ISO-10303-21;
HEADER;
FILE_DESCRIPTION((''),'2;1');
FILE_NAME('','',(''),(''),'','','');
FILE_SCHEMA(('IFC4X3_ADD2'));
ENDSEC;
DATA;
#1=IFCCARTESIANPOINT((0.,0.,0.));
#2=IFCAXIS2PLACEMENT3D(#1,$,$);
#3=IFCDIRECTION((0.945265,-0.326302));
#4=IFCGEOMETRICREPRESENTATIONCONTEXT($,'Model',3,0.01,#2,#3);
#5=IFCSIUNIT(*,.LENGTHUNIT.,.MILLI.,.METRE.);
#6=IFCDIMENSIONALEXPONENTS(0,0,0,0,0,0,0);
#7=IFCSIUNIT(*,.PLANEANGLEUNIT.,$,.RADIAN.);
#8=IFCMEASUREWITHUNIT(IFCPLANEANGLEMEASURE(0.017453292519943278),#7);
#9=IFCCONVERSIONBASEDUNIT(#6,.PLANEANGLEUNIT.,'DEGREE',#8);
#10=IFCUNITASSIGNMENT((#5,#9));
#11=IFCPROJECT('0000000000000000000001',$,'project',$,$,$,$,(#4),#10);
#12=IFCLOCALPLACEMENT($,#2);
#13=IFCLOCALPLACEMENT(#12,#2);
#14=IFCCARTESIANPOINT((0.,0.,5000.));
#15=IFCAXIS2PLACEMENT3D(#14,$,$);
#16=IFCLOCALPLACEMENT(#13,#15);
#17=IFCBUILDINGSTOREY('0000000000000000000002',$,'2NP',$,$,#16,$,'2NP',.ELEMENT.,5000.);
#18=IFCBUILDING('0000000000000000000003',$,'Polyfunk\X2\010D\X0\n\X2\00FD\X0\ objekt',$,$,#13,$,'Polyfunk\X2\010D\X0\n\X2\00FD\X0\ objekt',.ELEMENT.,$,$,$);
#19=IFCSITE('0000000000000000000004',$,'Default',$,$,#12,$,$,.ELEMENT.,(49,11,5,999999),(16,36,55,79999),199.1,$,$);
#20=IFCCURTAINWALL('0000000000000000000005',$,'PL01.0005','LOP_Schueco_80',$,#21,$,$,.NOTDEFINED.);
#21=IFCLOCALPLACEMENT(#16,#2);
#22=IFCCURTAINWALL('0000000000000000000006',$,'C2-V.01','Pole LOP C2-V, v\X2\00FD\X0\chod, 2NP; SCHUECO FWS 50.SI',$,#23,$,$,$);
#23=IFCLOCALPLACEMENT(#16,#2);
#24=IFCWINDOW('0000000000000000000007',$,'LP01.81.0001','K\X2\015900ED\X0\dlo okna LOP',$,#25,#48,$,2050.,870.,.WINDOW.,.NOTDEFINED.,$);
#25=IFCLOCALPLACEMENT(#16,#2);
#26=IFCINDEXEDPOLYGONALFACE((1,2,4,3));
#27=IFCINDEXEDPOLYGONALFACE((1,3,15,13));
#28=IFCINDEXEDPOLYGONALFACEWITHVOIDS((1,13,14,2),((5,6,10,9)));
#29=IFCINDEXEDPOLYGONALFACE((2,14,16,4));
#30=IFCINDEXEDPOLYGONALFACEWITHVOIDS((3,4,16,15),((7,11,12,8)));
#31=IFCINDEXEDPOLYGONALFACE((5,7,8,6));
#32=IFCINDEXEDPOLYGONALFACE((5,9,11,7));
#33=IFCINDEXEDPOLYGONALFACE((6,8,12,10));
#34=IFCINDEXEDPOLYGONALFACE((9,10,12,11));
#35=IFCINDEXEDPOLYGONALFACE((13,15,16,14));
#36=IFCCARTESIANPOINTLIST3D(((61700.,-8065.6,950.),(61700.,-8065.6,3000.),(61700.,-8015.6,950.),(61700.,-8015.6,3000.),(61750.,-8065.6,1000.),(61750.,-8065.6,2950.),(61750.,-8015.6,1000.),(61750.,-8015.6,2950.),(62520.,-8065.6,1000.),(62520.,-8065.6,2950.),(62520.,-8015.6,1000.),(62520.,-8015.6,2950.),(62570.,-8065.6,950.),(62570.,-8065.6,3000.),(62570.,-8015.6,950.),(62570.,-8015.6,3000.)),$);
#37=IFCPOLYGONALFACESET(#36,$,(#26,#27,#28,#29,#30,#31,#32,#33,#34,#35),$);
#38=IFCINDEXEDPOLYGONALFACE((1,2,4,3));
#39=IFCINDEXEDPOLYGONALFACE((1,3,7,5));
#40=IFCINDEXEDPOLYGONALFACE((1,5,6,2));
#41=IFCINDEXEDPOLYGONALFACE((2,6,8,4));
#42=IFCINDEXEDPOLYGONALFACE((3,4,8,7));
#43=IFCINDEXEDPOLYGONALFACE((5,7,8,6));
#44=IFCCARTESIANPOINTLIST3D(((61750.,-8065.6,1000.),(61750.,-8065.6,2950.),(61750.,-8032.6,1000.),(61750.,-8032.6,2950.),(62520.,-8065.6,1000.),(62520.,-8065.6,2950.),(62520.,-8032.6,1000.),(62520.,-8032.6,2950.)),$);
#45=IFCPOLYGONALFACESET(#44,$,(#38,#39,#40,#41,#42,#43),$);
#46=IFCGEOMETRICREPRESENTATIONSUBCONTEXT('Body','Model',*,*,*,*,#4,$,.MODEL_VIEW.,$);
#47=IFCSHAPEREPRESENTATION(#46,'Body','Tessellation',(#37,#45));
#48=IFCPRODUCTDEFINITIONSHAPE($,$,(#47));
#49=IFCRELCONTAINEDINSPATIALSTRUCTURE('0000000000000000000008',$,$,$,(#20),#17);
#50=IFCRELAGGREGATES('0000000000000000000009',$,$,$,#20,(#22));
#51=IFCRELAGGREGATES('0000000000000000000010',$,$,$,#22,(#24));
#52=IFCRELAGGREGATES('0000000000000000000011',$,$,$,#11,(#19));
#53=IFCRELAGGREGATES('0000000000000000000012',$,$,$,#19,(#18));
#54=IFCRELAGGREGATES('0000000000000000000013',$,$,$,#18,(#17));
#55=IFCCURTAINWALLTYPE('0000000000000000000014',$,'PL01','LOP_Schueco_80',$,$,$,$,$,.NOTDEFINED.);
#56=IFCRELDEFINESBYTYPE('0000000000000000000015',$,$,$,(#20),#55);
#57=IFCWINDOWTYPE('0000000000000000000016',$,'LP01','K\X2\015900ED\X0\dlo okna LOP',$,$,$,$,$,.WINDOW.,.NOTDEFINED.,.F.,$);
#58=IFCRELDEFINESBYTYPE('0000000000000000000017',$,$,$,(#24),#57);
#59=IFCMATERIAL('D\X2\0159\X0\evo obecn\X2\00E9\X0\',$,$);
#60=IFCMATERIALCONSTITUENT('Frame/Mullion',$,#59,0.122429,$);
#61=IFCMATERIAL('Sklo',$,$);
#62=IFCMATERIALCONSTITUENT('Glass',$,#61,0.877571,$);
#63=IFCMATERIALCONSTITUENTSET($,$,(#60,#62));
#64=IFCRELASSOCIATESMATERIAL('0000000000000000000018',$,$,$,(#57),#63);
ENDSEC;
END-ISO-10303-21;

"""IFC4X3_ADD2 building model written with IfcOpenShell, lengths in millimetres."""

from ifc_helpers import new_model, entity, si_unit, converted_unit, direction, frame, frame_2d, origin, place, context, subcontext, project, spatial, polyline, rectangle, outline, extrude, source, transform, mapped, material, constituent, constituent_set, type_object, element, aggregate, save


model = new_model("IFC4X3_ADD2")

# Units and contexts
model_context = context("Model", 3, precision=0.01, world=origin(), true_north=direction((0.945265, -0.326302)))
body_context = subcontext(model_context, "Body", "Model", "MODEL_VIEW")
ifc_project = project(units=[si_unit("LENGTHUNIT", "METRE", prefix="MILLI"), converted_unit("PLANEANGLEUNIT", "DEGREE", entity("IfcPlaneAngleMeasure", 0.017453292519943278), si_unit("PLANEANGLEUNIT", "RADIAN"), dimensions=[0, 0, 0, 0, 0, 0, 0])], contexts=[model_context])

# Site, building, storey
site_placement = place(None, origin())
site = spatial("IfcSite", under=ifc_project, at=site_placement, Name="Default", CompositionType="ELEMENT", RefLatitude=(49, 11, 5, 999999), RefLongitude=(16, 36, 55, 79999), RefElevation=199.1)
building_placement = place(site_placement, origin())
building = spatial("IfcBuilding", under=site, at=building_placement, Name="Polyfunkčný objekt", LongName="Polyfunkčný objekt", CompositionType="ELEMENT")
storey_placement = place(building_placement, frame((0.0, 0.0, 5000.0)))
storey = spatial("IfcBuildingStorey", under=building, at=storey_placement, Name="2NP", LongName="2NP", CompositionType="ELEMENT", Elevation=5000.0)

# Curtain walls
curtain_wall_type = type_object("IfcCurtainWallType", Name="PL01", Description="LOP_Schueco_80", PredefinedType="NOTDEFINED")
curtain_wall_1_placement = place(storey_placement, frame((0.0, 0.0, -5000.0)))
curtain_wall_1 = element("IfcCurtainWall", 1, at=curtain_wall_1_placement, inside=storey, type_object=curtain_wall_type, Name="PL01.0005", Description="LOP_Schueco_80", PredefinedType="NOTDEFINED")
curtain_wall_2 = element("IfcCurtainWall", 2, Name="C2-V.01", Description="Pole LOP C2-V, východ, 2NP; SCHUECO FWS 50.SI")
aggregate(curtain_wall_1, [curtain_wall_2])

# Shared definitions
ifc_material_1 = material(Name="Sklo")

# Window
ifc_material_2 = material(Name="Dřevo obecné")
ifc_constituent_1 = constituent(ifc_material_2, Name="Frame/Mullion", fraction=0.122429)
ifc_constituent_2 = constituent(ifc_material_1, Name="Glass", fraction=0.877571)
ifc_constituent_set = constituent_set(constituents=[ifc_constituent_1, ifc_constituent_2])
window_type = type_object("IfcWindowType", Name="LP01", Description="Křídlo okna LOP", ParameterTakesPrecedence=False, PartitioningType="NOTDEFINED", PredefinedType="WINDOW", material=ifc_constituent_set)
shared_shape_1 = source(origin(), body_context, "Body", "SweptSolid", [
    extrude(outline(polyline([(-1025.0, -435.0), (1025.0, -435.0), (1025.0, 435.0), (-1025.0, 435.0), (-1025.0, -435.0)]), holes=[polyline([(-975.0, -385.0), (-975.0, 385.0), (975.0, 385.0), (975.0, -385.0), (-975.0, -385.0)])]), frame((0.0, 50.0, 1025.0), z_axis=(0.0, -1.0, 0.0), x_axis=(0.0, 0.0, -1.0)), (0.0, 0.0, 1.0), 50.0),
    extrude(rectangle(XDim=770.0, YDim=33.0, at=frame_2d((0.0, 0.0), x_axis=(1.0, 0.0))), frame((0.0, 33.5, 50.0), z_axis=(0.0, 0.0, 1.0), x_axis=(-1.0, 0.0, 0.0)), (0.0, 0.0, 1.0), 1950.0),
])
window_1_placement = place(curtain_wall_1_placement, frame((62135.0, -8015.6, 5950.0), z_axis=(0.0, 0.0, 1.0), x_axis=(-1.0, 0.0, 0.0)))
window_1 = element("IfcWindow", 3, at=window_1_placement, type_object=window_type, Name="LP01.81.0001", Description="Křídlo okna LOP", OverallHeight=2050.0, OverallWidth=870.0, PartitioningType="NOTDEFINED", PredefinedType="WINDOW", context=body_context, shape_type="MappedRepresentation", body=[
    mapped(shared_shape_1, transform((0.0, 0.0, 0.0), scale=1.0)),
])
aggregate(curtain_wall_2, [window_1])

save(model, "model.ifc")
